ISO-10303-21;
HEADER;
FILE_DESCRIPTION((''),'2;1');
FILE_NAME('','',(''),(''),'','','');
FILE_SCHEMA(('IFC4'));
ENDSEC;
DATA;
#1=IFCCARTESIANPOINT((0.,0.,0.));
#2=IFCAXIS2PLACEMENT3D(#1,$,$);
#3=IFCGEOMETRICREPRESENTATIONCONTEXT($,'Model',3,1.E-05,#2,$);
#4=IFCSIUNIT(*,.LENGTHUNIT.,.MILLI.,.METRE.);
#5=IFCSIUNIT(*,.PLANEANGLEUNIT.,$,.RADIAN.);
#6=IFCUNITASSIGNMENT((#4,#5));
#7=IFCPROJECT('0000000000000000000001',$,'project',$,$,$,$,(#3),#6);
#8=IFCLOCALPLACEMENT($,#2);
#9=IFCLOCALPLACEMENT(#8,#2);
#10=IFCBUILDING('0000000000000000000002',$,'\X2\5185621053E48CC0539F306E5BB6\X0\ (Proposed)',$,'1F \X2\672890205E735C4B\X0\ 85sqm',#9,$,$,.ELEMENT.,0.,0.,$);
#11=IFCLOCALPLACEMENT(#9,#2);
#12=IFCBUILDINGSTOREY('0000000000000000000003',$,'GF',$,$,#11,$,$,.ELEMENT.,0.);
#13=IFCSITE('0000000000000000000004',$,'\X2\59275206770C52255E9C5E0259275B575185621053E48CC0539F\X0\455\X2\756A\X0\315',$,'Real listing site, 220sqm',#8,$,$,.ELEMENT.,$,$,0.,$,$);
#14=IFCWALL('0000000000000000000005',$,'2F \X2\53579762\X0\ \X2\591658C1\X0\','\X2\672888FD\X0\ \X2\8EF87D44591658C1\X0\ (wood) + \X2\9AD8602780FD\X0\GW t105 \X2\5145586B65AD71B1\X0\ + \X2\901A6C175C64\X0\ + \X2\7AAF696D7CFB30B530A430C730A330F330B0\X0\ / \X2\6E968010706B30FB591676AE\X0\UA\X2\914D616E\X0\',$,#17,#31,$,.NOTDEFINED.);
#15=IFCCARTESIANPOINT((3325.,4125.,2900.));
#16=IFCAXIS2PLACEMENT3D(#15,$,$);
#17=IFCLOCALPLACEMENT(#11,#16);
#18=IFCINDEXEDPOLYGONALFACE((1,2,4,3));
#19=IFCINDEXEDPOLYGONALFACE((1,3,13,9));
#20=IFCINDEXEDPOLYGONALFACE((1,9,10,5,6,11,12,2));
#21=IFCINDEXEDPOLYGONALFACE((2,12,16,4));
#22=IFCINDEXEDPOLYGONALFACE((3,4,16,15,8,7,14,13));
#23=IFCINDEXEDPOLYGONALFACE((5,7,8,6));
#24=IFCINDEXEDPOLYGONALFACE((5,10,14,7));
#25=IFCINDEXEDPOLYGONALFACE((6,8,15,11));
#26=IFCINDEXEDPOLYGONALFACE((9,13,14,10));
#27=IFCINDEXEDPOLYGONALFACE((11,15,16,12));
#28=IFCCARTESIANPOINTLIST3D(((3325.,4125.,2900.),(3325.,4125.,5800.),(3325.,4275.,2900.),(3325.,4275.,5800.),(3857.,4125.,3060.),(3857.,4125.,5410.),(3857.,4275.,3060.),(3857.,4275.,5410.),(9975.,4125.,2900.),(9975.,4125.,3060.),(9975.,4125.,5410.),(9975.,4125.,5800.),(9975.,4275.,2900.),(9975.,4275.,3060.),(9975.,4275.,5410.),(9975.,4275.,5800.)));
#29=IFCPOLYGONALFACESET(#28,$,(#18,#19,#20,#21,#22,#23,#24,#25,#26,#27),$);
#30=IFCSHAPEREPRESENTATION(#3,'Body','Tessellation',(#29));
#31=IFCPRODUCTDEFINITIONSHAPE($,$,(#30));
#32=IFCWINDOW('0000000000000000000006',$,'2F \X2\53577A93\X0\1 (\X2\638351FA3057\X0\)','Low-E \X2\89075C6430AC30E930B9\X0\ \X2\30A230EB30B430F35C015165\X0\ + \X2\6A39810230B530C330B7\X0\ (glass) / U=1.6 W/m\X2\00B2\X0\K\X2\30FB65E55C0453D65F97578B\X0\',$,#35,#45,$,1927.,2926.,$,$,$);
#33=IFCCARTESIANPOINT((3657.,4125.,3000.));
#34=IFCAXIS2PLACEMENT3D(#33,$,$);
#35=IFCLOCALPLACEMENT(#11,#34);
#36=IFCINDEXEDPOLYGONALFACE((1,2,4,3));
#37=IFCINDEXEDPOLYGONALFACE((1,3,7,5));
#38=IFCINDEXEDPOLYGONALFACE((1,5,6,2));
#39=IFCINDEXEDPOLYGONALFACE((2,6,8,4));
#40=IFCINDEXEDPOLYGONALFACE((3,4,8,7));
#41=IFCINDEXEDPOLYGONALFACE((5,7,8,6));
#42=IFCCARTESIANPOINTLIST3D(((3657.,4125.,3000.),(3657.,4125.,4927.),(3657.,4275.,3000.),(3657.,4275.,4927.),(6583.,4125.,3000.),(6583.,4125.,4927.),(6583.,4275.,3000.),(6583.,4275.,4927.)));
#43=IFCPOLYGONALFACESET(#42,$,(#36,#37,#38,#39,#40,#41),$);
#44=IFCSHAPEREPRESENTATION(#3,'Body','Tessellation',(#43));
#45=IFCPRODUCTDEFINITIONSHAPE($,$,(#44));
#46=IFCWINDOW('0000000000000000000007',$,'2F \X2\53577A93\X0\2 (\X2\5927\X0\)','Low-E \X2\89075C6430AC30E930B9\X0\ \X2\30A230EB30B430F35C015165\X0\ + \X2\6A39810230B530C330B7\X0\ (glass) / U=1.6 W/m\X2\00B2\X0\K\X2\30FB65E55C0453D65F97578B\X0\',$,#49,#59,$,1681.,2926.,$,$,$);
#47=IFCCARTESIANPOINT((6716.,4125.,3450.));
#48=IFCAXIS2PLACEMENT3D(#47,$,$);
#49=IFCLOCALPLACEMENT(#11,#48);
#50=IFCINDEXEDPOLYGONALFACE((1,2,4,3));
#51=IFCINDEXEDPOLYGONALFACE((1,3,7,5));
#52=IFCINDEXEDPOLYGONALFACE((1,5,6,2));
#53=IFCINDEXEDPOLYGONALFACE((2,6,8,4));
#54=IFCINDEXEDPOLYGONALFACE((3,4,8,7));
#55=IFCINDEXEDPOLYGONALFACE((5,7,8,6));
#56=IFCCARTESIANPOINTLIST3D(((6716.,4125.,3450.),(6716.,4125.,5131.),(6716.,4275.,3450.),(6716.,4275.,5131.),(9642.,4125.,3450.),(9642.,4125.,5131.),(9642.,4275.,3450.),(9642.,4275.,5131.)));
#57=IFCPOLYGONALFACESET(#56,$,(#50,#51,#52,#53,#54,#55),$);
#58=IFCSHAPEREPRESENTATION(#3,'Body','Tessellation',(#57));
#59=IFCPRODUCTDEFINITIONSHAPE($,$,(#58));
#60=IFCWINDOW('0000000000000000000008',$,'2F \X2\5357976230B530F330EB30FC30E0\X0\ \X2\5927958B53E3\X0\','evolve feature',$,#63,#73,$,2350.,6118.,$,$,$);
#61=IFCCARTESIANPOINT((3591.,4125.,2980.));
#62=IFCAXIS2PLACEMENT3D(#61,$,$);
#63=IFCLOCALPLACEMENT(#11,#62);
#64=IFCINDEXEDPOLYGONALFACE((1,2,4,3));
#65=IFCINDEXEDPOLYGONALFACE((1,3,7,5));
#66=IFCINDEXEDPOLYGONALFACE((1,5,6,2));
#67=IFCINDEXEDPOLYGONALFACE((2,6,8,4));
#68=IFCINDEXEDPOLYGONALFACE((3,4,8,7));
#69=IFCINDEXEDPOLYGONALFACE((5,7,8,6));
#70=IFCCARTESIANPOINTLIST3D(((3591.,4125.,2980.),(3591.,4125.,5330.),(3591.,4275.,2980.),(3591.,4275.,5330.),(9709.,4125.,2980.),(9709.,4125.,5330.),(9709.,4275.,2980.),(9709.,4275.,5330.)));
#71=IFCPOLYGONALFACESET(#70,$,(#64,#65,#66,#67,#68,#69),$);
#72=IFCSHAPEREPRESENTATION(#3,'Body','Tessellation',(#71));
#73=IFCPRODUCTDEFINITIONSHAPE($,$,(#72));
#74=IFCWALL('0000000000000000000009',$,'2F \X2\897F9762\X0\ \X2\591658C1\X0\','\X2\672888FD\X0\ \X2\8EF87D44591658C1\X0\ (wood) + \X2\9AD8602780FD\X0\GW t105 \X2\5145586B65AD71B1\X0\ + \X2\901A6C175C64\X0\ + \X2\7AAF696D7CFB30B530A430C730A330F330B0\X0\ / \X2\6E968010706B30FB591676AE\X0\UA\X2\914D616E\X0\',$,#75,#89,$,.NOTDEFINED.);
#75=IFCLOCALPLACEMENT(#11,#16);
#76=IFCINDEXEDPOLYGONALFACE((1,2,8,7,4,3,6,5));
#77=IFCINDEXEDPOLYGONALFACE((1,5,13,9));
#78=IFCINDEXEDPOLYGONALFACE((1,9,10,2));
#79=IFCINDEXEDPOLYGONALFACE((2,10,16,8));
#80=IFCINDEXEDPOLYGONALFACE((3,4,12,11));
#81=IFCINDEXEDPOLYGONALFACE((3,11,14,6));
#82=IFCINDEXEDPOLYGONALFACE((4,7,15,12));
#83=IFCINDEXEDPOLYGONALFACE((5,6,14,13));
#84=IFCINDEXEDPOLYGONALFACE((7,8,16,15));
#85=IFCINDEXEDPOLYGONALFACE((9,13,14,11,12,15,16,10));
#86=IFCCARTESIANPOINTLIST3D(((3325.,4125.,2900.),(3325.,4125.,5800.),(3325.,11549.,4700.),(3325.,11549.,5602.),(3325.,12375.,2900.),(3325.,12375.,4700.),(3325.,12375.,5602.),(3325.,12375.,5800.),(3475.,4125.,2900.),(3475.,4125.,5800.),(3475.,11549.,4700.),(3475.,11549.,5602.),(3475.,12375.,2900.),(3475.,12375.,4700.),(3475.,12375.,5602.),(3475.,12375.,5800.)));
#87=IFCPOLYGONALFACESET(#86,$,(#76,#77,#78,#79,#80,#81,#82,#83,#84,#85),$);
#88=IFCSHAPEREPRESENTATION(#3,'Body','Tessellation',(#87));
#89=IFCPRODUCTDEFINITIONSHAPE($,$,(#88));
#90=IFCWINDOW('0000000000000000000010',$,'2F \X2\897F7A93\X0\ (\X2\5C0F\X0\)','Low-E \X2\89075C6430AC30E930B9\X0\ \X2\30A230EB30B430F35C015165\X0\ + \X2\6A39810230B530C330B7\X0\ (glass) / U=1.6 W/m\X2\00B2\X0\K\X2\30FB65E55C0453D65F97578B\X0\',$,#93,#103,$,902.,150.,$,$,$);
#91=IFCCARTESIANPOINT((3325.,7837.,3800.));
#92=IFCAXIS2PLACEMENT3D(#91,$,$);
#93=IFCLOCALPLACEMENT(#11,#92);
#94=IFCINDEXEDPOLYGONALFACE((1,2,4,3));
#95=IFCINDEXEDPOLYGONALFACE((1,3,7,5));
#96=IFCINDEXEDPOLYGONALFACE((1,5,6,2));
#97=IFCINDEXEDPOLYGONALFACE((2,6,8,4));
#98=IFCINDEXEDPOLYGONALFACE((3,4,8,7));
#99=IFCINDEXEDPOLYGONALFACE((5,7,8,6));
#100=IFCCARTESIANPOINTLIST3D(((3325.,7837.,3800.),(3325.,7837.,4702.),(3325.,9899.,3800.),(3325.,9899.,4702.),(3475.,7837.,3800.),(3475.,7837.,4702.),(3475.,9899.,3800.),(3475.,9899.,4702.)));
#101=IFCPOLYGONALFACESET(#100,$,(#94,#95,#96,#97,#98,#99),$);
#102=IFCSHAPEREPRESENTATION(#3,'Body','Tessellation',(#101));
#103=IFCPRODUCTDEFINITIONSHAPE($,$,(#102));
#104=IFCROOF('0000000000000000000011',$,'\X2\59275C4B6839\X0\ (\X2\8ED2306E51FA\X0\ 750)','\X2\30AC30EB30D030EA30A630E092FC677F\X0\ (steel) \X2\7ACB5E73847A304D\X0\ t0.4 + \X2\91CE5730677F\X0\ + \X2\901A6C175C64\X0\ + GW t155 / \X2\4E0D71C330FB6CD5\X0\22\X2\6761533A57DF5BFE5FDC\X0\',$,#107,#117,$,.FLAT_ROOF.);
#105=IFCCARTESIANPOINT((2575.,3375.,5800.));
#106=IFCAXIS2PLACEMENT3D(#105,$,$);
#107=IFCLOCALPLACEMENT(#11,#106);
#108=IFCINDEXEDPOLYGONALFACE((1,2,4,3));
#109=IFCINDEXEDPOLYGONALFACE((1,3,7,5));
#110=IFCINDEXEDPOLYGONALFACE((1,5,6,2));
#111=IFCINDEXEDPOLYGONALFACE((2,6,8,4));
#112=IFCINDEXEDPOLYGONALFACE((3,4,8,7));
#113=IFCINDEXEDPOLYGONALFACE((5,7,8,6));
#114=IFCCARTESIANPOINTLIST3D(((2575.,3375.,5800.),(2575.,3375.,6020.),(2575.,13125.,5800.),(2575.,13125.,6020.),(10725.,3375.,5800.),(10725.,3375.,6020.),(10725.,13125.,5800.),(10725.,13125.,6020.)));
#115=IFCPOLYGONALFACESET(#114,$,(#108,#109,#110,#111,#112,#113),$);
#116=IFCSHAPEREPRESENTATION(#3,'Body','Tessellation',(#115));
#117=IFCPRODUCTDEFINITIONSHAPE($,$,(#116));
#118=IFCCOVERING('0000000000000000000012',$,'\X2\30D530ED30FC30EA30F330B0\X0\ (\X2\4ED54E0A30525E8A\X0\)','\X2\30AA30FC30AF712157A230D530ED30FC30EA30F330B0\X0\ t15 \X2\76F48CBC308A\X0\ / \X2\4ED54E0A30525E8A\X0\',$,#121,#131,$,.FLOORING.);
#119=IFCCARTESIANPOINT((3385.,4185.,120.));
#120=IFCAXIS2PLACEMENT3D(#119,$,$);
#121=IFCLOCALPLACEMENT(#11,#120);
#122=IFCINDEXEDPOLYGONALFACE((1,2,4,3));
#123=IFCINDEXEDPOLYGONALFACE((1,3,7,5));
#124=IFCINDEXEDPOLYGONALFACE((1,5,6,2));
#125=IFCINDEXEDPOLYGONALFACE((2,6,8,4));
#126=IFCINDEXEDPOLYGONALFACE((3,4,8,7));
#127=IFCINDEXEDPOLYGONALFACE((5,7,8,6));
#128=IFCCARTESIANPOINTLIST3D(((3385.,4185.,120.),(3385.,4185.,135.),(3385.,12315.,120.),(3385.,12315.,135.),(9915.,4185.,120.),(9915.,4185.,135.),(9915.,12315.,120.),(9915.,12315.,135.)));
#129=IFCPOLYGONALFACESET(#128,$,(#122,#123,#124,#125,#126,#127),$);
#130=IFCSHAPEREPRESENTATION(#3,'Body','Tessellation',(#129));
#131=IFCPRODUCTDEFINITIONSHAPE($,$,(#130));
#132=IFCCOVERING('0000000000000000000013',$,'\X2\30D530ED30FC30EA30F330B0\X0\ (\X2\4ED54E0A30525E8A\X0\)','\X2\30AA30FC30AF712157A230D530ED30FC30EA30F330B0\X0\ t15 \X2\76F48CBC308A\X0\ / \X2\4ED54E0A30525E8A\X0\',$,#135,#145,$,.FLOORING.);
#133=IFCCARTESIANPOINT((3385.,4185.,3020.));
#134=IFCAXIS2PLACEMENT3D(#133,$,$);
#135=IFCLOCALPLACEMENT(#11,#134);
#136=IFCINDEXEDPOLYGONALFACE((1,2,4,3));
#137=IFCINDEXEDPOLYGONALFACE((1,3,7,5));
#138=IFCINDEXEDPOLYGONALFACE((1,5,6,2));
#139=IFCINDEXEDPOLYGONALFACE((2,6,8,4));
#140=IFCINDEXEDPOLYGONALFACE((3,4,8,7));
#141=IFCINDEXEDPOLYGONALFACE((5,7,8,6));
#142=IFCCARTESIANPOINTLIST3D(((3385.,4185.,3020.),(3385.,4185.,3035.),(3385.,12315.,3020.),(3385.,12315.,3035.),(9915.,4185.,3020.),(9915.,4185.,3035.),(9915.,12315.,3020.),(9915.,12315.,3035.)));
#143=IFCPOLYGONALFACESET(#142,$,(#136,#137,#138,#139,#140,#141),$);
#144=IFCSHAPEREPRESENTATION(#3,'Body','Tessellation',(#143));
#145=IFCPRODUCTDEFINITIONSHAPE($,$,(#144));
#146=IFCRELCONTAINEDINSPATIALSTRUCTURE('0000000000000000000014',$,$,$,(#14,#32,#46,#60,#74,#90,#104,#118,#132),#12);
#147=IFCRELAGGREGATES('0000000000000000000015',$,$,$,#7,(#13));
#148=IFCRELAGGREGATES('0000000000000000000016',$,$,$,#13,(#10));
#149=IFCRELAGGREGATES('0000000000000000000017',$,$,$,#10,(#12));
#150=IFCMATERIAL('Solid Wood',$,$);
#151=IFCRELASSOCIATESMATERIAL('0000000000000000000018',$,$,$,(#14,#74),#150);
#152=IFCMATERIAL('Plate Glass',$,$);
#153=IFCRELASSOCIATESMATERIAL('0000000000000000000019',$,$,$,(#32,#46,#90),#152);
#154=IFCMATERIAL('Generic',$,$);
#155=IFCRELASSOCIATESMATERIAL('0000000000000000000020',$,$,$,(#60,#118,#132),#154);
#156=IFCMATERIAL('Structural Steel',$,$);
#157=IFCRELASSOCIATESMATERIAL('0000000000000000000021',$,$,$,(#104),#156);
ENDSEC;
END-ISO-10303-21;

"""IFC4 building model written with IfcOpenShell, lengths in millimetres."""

from ifc_helpers import new_model, si_unit, frame, frame_2d, origin, place, context, project, spatial, rectangle, extrude, material, element, fill, save


model = new_model("IFC4")

# Units and contexts
model_context = context("Model", 3, precision=1e-05, world=origin())
ifc_project = project(units=[si_unit("LENGTHUNIT", "METRE", prefix="MILLI"), si_unit("PLANEANGLEUNIT", "RADIAN")], contexts=[model_context])

# Site, building, storey
site_placement = place(None, origin())
site = spatial("IfcSite", under=ifc_project, at=site_placement, Name="大分県別府市大字内成古賀原455番315", ObjectType="Real listing site, 220sqm", CompositionType="ELEMENT", RefElevation=0.0)
building_placement = place(site_placement, origin())
building = spatial("IfcBuilding", under=site, at=building_placement, Name="内成古賀原の家 (Proposed)", ObjectType="1F 木造平屋 85sqm", CompositionType="ELEMENT", ElevationOfRefHeight=0.0, ElevationOfTerrain=0.0)
storey_placement = place(building_placement, origin())
storey = spatial("IfcBuildingStorey", under=building, at=storey_placement, Name="GF", CompositionType="ELEMENT", Elevation=0.0)

# Shared definitions
ifc_material_1 = material(Name="Solid Wood")
ifc_material_2 = material(Name="Generic")

# Shared definitions
ifc_material_3 = material(Name="Plate Glass")

# Wall, openings, windows
wall_1_placement = place(storey_placement, frame((3325.0, 4125.0, 2900.0)))
wall_1 = element("IfcWall", 1, at=wall_1_placement, inside=storey, material=ifc_material_1, Name="2F 南面 外壁", Description="木製 軸組外壁 (wood) + 高性能GW t105 充填断熱 + 通気層 + 窯業系サイディング / 準耐火・外皮UA配慮", PredefinedType="NOTDEFINED", context=model_context, shape_type="SweptSolid", body=[
    extrude(rectangle(XDim=6650.0, YDim=150.0, at=frame_2d((3325.0, 75.0))), frame((3325.0, 4125.0, 2900.0)), (0.0, 0.0, 1.0), 2900.0),
])
opening_1_placement = place(storey_placement, frame((3657.0, 4125.0, 3000.0)))
opening_1 = element("IfcOpeningElement", 2, at=opening_1_placement, cuts=wall_1, PredefinedType="NOTDEFINED", context=model_context, shape_type="SweptSolid", body=[
    extrude(rectangle(XDim=2926.0, YDim=150.0, at=frame_2d((1463.0, 75.0))), frame((3657.0, 4125.0, 3000.0)), (0.0, 0.0, 1.0), 1927.0),
])
opening_2_placement = place(storey_placement, frame((6716.0, 4125.0, 3450.0)))
opening_2 = element("IfcOpeningElement", 3, at=opening_2_placement, cuts=wall_1, PredefinedType="NOTDEFINED", context=model_context, shape_type="SweptSolid", body=[
    extrude(rectangle(XDim=2926.0, YDim=150.0, at=frame_2d((1463.0, 75.0))), frame((6716.0, 4125.0, 3450.0)), (0.0, 0.0, 1.0), 1681.0),
])
opening_3_placement = place(storey_placement, frame((3591.0, 4125.0, 2980.0)))
opening_3 = element("IfcOpeningElement", 4, at=opening_3_placement, cuts=wall_1, PredefinedType="NOTDEFINED", context=model_context, shape_type="SweptSolid", body=[
    extrude(rectangle(XDim=6118.0, YDim=150.0, at=frame_2d((3059.0, 75.0))), frame((3591.0, 4125.0, 2980.0)), (0.0, 0.0, 1.0), 2350.0),
])
window_1_placement = place(storey_placement, frame((3657.0, 4125.0, 3000.0)))
window_1 = element("IfcWindow", 5, at=window_1_placement, inside=storey, material=ifc_material_3, Name="2F 南窓1 (掃出し)", Description="Low-E 複層ガラス アルゴン封入 + 樹脂サッシ (glass) / U=1.6 W/m²K・日射取得型", OverallHeight=1927.0, OverallWidth=2926.0, context=model_context, shape_type="SweptSolid", body=[
    extrude(rectangle(XDim=2926.0, YDim=150.0, at=frame_2d((1463.0, 75.0))), frame((3657.0, 4125.0, 3000.0)), (0.0, 0.0, 1.0), 1927.0),
])
fill(opening_1, window_1)
window_2_placement = place(storey_placement, frame((6716.0, 4125.0, 3450.0)))
window_2 = element("IfcWindow", 6, at=window_2_placement, inside=storey, material=ifc_material_3, Name="2F 南窓2 (大)", Description="Low-E 複層ガラス アルゴン封入 + 樹脂サッシ (glass) / U=1.6 W/m²K・日射取得型", OverallHeight=1681.0, OverallWidth=2926.0, context=model_context, shape_type="SweptSolid", body=[
    extrude(rectangle(XDim=2926.0, YDim=150.0, at=frame_2d((1463.0, 75.0))), frame((6716.0, 4125.0, 3450.0)), (0.0, 0.0, 1.0), 1681.0),
])
fill(opening_2, window_2)
window_3_placement = place(storey_placement, frame((3591.0, 4125.0, 2980.0)))
window_3 = element("IfcWindow", 7, at=window_3_placement, inside=storey, material=ifc_material_2, Name="2F 南面サンルーム 大開口", Description="evolve feature", OverallHeight=2350.0, OverallWidth=6118.0, context=model_context, shape_type="SweptSolid", body=[
    extrude(rectangle(XDim=6118.0, YDim=150.0, at=frame_2d((3059.0, 75.0))), frame((3591.0, 4125.0, 2980.0)), (0.0, 0.0, 1.0), 2350.0),
])
fill(opening_3, window_3)

# Wall, opening, window
wall_2_placement = place(storey_placement, frame((3325.0, 4125.0, 2900.0)))
wall_2 = element("IfcWall", 8, at=wall_2_placement, inside=storey, material=ifc_material_1, Name="2F 西面 外壁", Description="木製 軸組外壁 (wood) + 高性能GW t105 充填断熱 + 通気層 + 窯業系サイディング / 準耐火・外皮UA配慮", PredefinedType="NOTDEFINED", context=model_context, shape_type="SweptSolid", body=[
    extrude(rectangle(XDim=150.0, YDim=8250.0, at=frame_2d((75.0, 4125.0))), frame((3325.0, 4125.0, 2900.0)), (0.0, 0.0, 1.0), 2900.0),
])
opening_4_placement = place(storey_placement, frame((3325.0, 7837.0, 3800.0)))
opening_4 = element("IfcOpeningElement", 9, at=opening_4_placement, cuts=wall_2, PredefinedType="NOTDEFINED", context=model_context, shape_type="SweptSolid", body=[
    extrude(rectangle(XDim=150.0, YDim=2062.0, at=frame_2d((75.0, 1031.0))), frame((3325.0, 7837.0, 3800.0)), (0.0, 0.0, 1.0), 902.0),
])
window_4_placement = place(storey_placement, frame((3325.0, 7837.0, 3800.0)))
window_4 = element("IfcWindow", 10, at=window_4_placement, inside=storey, material=ifc_material_3, Name="2F 西窓 (小)", Description="Low-E 複層ガラス アルゴン封入 + 樹脂サッシ (glass) / U=1.6 W/m²K・日射取得型", OverallHeight=902.0, OverallWidth=150.0, context=model_context, shape_type="SweptSolid", body=[
    extrude(rectangle(XDim=150.0, YDim=2062.0, at=frame_2d((75.0, 1031.0))), frame((3325.0, 7837.0, 3800.0)), (0.0, 0.0, 1.0), 902.0),
])
fill(opening_4, window_4)

# Roof
ifc_material_4 = material(Name="Structural Steel")
roof_placement = place(storey_placement, frame((2575.0, 3375.0, 5800.0)))
element("IfcRoof", 11, at=roof_placement, inside=storey, material=ifc_material_4, Name="大屋根 (軒の出 750)", Description="ガルバリウム鋼板 (steel) 立平葺き t0.4 + 野地板 + 通気層 + GW t155 / 不燃・法22条区域対応", PredefinedType="FLAT_ROOF", context=model_context, shape_type="SweptSolid", body=[
    extrude(rectangle(XDim=8150.0, YDim=9750.0, at=frame_2d((4075.0, 4875.0))), frame((2575.0, 3375.0, 5800.0)), (0.0, 0.0, 1.0), 220.0),
])

# Coverings
covering_1_placement = place(storey_placement, frame((3385.0, 4185.0, 120.0)))
element("IfcCovering", 12, at=covering_1_placement, inside=storey, material=ifc_material_2, Name="フローリング (仕上げ床)", Description="オーク無垢フローリング t15 直貼り / 仕上げ床", PredefinedType="FLOORING", context=model_context, shape_type="SweptSolid", body=[
    extrude(rectangle(XDim=6530.0, YDim=8130.0, at=frame_2d((3265.0, 4065.0))), frame((3385.0, 4185.0, 120.0)), (0.0, 0.0, 1.0), 15.0),
])
covering_2_placement = place(storey_placement, frame((3385.0, 4185.0, 3020.0)))
element("IfcCovering", 13, at=covering_2_placement, inside=storey, material=ifc_material_2, Name="フローリング (仕上げ床)", Description="オーク無垢フローリング t15 直貼り / 仕上げ床", PredefinedType="FLOORING", context=model_context, shape_type="SweptSolid", body=[
    extrude(rectangle(XDim=6530.0, YDim=8130.0, at=frame_2d((3265.0, 4065.0))), frame((3385.0, 4185.0, 3020.0)), (0.0, 0.0, 1.0), 15.0),
])

save(model, "model.ifc")
